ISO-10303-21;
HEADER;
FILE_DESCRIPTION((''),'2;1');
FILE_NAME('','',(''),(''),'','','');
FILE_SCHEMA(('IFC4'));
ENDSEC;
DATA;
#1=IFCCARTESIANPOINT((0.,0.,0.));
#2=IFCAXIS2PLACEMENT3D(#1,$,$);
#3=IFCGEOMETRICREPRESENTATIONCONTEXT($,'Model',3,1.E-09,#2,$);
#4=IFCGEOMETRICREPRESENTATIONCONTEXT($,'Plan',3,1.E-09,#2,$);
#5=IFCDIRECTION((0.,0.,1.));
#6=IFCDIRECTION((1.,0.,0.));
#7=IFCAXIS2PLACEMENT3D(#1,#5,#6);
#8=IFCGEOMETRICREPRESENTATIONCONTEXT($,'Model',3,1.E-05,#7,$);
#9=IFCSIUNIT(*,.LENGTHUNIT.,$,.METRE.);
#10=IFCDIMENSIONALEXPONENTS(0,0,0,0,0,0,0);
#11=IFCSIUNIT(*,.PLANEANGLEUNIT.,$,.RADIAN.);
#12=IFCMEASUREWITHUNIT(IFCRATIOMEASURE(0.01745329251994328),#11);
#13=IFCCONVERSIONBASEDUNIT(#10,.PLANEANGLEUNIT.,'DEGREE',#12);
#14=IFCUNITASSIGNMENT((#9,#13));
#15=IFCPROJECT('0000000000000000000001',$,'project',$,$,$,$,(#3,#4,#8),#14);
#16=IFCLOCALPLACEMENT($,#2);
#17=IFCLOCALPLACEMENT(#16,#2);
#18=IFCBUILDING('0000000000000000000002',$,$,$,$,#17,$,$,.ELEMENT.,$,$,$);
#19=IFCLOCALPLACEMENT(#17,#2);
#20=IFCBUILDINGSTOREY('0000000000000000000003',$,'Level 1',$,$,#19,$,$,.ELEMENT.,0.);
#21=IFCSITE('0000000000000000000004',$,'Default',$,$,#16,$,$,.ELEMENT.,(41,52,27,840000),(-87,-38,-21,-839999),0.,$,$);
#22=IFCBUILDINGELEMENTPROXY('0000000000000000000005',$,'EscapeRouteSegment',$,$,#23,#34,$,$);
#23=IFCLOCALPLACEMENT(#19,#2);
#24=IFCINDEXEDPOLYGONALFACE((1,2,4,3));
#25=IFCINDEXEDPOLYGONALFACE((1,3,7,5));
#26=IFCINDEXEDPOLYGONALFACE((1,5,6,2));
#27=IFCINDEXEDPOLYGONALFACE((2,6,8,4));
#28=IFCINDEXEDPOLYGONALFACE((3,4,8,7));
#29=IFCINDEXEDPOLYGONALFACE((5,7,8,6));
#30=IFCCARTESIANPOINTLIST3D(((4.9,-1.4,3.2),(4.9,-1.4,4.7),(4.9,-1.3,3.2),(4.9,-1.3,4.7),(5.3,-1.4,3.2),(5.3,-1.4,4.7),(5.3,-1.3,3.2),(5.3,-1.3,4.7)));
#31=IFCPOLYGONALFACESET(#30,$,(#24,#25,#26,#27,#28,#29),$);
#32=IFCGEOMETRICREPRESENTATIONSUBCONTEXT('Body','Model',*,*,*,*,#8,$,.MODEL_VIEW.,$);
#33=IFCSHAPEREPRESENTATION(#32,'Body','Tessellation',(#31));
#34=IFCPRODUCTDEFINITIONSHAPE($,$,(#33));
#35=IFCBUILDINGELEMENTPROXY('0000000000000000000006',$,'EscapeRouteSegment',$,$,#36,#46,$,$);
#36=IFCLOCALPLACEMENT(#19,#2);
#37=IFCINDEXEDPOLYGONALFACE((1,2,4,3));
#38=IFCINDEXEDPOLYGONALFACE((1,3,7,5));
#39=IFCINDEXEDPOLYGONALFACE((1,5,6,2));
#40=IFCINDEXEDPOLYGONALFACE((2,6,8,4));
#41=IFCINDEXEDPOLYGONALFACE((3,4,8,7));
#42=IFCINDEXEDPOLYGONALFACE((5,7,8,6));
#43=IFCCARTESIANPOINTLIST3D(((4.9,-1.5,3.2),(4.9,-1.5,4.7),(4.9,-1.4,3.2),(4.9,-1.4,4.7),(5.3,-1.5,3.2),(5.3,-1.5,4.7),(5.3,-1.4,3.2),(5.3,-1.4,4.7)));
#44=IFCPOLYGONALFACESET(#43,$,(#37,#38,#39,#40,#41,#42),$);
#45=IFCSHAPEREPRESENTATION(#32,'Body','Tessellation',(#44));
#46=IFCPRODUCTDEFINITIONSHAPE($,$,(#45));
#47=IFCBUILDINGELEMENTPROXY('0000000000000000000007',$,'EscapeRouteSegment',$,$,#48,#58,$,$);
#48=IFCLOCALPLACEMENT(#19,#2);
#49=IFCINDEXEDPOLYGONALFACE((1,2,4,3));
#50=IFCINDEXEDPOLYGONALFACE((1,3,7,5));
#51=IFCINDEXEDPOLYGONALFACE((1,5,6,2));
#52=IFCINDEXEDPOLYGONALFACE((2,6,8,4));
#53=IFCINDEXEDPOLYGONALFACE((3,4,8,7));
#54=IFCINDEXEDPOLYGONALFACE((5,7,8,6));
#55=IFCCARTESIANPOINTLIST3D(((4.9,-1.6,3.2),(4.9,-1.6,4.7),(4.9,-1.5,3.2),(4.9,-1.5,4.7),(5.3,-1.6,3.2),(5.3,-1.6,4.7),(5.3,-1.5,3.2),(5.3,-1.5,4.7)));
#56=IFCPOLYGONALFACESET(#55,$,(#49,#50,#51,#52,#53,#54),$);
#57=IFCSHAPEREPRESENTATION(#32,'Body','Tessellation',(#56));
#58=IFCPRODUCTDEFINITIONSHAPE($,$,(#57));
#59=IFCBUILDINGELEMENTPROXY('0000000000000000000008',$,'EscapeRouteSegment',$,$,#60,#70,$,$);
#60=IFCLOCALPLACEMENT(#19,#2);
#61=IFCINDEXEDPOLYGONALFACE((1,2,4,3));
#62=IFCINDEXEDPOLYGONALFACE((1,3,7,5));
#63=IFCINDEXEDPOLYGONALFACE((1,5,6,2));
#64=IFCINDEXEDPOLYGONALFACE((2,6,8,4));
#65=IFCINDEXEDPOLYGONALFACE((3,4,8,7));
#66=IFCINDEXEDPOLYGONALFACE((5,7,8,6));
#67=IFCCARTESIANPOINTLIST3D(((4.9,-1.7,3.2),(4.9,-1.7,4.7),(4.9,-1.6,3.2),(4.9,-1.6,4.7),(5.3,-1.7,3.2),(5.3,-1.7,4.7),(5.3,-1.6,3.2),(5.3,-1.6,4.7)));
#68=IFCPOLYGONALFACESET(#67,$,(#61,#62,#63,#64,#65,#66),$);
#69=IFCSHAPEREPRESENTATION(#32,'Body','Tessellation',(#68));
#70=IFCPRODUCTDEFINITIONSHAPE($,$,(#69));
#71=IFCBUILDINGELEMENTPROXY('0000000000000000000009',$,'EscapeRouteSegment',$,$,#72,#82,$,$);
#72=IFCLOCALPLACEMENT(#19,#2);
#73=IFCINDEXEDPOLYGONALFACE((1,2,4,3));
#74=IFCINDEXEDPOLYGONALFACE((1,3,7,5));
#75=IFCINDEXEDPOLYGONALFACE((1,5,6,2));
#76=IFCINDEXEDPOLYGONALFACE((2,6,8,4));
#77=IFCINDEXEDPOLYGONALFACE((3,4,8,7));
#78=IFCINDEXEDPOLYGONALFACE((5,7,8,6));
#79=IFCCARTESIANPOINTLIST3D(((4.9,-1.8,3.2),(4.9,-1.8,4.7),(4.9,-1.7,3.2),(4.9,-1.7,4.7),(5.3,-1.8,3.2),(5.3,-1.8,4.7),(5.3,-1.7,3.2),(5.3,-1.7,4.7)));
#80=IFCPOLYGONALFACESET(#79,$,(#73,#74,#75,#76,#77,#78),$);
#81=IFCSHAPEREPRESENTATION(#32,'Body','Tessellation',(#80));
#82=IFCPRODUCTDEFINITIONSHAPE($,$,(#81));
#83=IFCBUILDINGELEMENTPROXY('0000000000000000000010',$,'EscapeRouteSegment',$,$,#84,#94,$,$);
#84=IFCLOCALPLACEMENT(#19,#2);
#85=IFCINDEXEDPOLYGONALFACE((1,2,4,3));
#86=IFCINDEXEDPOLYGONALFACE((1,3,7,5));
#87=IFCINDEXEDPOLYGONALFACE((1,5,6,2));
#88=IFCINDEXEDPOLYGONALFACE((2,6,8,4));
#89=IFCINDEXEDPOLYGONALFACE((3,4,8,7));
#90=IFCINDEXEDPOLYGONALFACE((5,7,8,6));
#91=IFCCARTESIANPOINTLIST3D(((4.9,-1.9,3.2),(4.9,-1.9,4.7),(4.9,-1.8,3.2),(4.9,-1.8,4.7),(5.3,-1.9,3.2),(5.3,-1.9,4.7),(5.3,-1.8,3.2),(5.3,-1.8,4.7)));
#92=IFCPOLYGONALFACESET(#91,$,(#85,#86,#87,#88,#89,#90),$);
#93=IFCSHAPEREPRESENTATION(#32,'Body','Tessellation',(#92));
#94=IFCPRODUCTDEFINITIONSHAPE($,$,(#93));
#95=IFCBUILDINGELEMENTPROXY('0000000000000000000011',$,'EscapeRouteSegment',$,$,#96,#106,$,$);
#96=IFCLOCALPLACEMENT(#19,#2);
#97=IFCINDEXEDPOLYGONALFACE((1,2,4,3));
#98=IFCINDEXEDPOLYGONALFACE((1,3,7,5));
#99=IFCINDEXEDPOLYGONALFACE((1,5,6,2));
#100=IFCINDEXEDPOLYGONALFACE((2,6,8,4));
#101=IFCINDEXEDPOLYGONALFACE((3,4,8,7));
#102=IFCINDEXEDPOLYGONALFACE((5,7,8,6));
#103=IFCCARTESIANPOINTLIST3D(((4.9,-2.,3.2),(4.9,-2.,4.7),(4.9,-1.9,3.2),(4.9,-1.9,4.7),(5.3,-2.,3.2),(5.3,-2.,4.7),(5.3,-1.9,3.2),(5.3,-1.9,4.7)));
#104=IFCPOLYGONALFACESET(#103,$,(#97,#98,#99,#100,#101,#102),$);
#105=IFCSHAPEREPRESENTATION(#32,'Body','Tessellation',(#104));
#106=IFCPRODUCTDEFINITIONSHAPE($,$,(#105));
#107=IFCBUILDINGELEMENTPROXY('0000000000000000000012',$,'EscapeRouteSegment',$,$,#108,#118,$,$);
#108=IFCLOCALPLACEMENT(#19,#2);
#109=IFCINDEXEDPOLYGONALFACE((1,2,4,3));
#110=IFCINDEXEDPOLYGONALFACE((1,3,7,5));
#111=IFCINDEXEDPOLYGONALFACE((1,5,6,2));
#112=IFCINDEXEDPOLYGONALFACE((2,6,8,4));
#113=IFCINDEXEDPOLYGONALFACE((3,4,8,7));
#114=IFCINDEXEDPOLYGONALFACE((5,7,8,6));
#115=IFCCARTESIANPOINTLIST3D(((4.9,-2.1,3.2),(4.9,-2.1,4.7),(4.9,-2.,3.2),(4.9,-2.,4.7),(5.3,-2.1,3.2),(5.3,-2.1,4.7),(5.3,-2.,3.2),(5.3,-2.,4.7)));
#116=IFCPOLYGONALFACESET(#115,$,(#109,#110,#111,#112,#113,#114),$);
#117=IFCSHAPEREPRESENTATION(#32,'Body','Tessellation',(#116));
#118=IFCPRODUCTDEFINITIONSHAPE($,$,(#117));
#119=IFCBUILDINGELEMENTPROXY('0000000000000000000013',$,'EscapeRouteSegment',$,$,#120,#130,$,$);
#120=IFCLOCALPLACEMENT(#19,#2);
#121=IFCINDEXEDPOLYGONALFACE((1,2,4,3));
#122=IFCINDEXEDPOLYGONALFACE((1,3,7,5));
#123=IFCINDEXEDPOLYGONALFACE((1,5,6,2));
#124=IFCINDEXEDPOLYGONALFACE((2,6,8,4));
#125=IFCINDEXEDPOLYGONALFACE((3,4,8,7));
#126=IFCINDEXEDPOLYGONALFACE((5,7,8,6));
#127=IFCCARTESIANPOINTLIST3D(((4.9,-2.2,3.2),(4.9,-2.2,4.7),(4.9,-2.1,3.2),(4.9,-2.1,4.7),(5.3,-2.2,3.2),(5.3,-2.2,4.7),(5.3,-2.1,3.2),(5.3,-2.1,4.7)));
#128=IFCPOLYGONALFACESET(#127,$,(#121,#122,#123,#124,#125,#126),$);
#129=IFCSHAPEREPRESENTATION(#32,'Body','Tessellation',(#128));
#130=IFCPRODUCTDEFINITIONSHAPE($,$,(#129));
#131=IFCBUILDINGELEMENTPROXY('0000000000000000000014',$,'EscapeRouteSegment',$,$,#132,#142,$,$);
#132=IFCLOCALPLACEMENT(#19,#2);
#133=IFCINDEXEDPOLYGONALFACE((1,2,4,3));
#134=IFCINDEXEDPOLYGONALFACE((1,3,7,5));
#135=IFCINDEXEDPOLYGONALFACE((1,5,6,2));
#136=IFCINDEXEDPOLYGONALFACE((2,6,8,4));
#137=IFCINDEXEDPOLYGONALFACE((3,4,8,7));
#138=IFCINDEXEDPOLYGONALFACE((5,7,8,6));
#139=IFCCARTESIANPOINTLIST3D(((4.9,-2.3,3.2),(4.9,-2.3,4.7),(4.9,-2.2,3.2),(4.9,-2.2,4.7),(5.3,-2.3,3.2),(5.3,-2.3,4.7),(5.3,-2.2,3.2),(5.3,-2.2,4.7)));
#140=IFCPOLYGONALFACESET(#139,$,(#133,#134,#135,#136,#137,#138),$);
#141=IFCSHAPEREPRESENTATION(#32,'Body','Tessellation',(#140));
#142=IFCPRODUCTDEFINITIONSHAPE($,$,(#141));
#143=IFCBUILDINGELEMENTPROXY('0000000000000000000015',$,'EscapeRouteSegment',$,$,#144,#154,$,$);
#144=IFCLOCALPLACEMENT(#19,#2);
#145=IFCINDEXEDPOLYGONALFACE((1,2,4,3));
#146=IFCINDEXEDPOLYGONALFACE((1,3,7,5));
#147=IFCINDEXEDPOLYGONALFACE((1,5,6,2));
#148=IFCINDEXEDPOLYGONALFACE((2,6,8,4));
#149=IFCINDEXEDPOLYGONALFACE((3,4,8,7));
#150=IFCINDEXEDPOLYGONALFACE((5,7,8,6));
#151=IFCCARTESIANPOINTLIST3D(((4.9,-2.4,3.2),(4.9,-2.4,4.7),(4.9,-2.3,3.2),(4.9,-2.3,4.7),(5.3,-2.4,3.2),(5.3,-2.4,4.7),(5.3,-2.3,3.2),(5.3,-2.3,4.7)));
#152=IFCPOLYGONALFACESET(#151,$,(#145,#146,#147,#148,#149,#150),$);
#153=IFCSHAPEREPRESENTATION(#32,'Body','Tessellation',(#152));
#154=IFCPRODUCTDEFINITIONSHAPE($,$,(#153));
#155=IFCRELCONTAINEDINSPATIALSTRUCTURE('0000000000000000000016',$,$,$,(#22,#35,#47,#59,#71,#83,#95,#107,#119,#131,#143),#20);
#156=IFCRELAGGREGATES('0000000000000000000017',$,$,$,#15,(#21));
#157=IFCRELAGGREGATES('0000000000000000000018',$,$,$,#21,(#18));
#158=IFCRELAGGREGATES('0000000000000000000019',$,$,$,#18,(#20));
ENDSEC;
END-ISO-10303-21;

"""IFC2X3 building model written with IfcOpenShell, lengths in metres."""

from ifc_helpers import new_model, entity, si_unit, converted_unit, frame, origin, origin_with_axes, place, context, subcontext, project, spatial, polyline, outline, extrude, element, save


model = new_model("IFC2X3")

# Units and contexts
model_context_1 = context("Model", 3, precision=1e-09, world=origin())
plan_context = context("Plan", 3, precision=1e-09, world=origin())
model_context_2 = context("Model", 3, precision=1e-05, world=origin_with_axes())
body_context = subcontext(model_context_2, "Body", "Model", "MODEL_VIEW")
ifc_project = project(units=[si_unit("LENGTHUNIT", "METRE"), converted_unit("PLANEANGLEUNIT", "DEGREE", entity("IfcRatioMeasure", 0.01745329251994328), si_unit("PLANEANGLEUNIT", "RADIAN"), dimensions=[0, 0, 0, 0, 0, 0, 0])], contexts=[model_context_1, plan_context, model_context_2])

# Site, building, storey
site_placement = place(None, origin())
site = spatial("IfcSite", under=ifc_project, at=site_placement, Name="Default", CompositionType="ELEMENT", RefLatitude=(41, 52, 27, 840000), RefLongitude=(-87, -38, -21, -839999), RefElevation=0.0)
building_placement = place(site_placement, origin())
building = spatial("IfcBuilding", under=site, at=building_placement, CompositionType="ELEMENT")
storey_placement = place(building_placement, origin())
storey = spatial("IfcBuildingStorey", under=building, at=storey_placement, Name="Level 1", CompositionType="ELEMENT", Elevation=0.0)

# Building element proxies
for number, where, z_axis, x_axis, name in (
    (1, (5.1, -1.3, 3.2), (0.0, 0.0, 1.0), (0.0, -1.0, 0.0), "EscapeRouteSegment"),
    (2, (5.1, -1.4, 3.2), (0.0, 0.0, 1.0), (0.0, -1.0, 0.0), "EscapeRouteSegment"),
    (3, (5.1, -1.5, 3.2), (0.0, 0.0, 1.0), (0.0, -1.0, 0.0), "EscapeRouteSegment"),
    (4, (5.1, -1.6, 3.2), (0.0, 0.0, 1.0), (0.0, -1.0, 0.0), "EscapeRouteSegment"),
):
    element("IfcBuildingElementProxy", number, at=place(storey_placement, frame(where, z_axis=z_axis, x_axis=x_axis)), inside=storey, Name=name, context=body_context, shape_type="SweptSolid", body=[
        extrude(outline(polyline([(0.0, -0.2), (0.0, 0.2), (0.1, 0.2), (0.1, -0.2), (0.0, -0.2)])), origin_with_axes(), (0.0, 0.0, 1.0), 1.5),
    ])
proxy_1_placement = place(storey_placement, frame((5.1, -1.7, 3.2), z_axis=(0.0, 0.0, 1.0), x_axis=(0.0, -1.0, 0.0)))
element("IfcBuildingElementProxy", 5, at=proxy_1_placement, inside=storey, Name="EscapeRouteSegment", context=body_context, shape_type="SweptSolid", body=[
    extrude(outline(polyline([(0.0, -0.2), (0.0, 0.2), (0.1, 0.2), (0.1, -0.2), (0.0, -0.2)])), origin_with_axes(), (0.0, 0.0, 1.0), 1.5),
])
for number, where, z_axis, x_axis, name in (
    (6, (5.1, -1.8, 3.2), (0.0, 0.0, 1.0), (0.0, -1.0, 0.0), "EscapeRouteSegment"),
    (7, (5.1, -1.9, 3.2), (0.0, 0.0, 1.0), (0.0, -1.0, 0.0), "EscapeRouteSegment"),
):
    element("IfcBuildingElementProxy", number, at=place(storey_placement, frame(where, z_axis=z_axis, x_axis=x_axis)), inside=storey, Name=name, context=body_context, shape_type="SweptSolid", body=[
        extrude(outline(polyline([(0.0, -0.2), (0.0, 0.2), (0.1, 0.2), (0.1, -0.2), (0.0, -0.2)])), origin_with_axes(), (0.0, 0.0, 1.0), 1.5),
    ])
proxy_2_placement = place(storey_placement, frame((5.1, -2.0, 3.2), z_axis=(0.0, 0.0, 1.0), x_axis=(0.0, -1.0, 0.0)))
element("IfcBuildingElementProxy", 8, at=proxy_2_placement, inside=storey, Name="EscapeRouteSegment", context=body_context, shape_type="SweptSolid", body=[
    extrude(outline(polyline([(0.0, -0.2), (0.0, 0.2), (0.1, 0.2), (0.1, -0.2), (0.0, -0.2)])), origin_with_axes(), (0.0, 0.0, 1.0), 1.5),
])
proxy_3_placement = place(storey_placement, frame((5.1, -2.1, 3.2), z_axis=(0.0, 0.0, 1.0), x_axis=(0.0, -1.0, 0.0)))
element("IfcBuildingElementProxy", 9, at=proxy_3_placement, inside=storey, Name="EscapeRouteSegment", context=body_context, shape_type="SweptSolid", body=[
    extrude(outline(polyline([(0.0, -0.2), (0.0, 0.2), (0.1, 0.2), (0.1, -0.2), (0.0, -0.2)])), origin_with_axes(), (0.0, 0.0, 1.0), 1.5),
])
proxy_4_placement = place(storey_placement, frame((5.1, -2.2, 3.2), z_axis=(0.0, 0.0, 1.0), x_axis=(0.0, -1.0, 0.0)))
element("IfcBuildingElementProxy", 10, at=proxy_4_placement, inside=storey, Name="EscapeRouteSegment", context=body_context, shape_type="SweptSolid", body=[
    extrude(outline(polyline([(0.0, -0.2), (0.0, 0.2), (0.1, 0.2), (0.1, -0.2), (0.0, -0.2)])), origin_with_axes(), (0.0, 0.0, 1.0), 1.5),
])
proxy_5_placement = place(storey_placement, frame((5.1, -2.3, 3.2), z_axis=(0.0, 0.0, 1.0), x_axis=(0.0, -1.0, 0.0)))
element("IfcBuildingElementProxy", 11, at=proxy_5_placement, inside=storey, Name="EscapeRouteSegment", context=body_context, shape_type="SweptSolid", body=[
    extrude(outline(polyline([(0.0, -0.2), (0.0, 0.2), (0.1, 0.2), (0.1, -0.2), (0.0, -0.2)])), origin_with_axes(), (0.0, 0.0, 1.0), 1.5),
])

save(model, "model.ifc")
